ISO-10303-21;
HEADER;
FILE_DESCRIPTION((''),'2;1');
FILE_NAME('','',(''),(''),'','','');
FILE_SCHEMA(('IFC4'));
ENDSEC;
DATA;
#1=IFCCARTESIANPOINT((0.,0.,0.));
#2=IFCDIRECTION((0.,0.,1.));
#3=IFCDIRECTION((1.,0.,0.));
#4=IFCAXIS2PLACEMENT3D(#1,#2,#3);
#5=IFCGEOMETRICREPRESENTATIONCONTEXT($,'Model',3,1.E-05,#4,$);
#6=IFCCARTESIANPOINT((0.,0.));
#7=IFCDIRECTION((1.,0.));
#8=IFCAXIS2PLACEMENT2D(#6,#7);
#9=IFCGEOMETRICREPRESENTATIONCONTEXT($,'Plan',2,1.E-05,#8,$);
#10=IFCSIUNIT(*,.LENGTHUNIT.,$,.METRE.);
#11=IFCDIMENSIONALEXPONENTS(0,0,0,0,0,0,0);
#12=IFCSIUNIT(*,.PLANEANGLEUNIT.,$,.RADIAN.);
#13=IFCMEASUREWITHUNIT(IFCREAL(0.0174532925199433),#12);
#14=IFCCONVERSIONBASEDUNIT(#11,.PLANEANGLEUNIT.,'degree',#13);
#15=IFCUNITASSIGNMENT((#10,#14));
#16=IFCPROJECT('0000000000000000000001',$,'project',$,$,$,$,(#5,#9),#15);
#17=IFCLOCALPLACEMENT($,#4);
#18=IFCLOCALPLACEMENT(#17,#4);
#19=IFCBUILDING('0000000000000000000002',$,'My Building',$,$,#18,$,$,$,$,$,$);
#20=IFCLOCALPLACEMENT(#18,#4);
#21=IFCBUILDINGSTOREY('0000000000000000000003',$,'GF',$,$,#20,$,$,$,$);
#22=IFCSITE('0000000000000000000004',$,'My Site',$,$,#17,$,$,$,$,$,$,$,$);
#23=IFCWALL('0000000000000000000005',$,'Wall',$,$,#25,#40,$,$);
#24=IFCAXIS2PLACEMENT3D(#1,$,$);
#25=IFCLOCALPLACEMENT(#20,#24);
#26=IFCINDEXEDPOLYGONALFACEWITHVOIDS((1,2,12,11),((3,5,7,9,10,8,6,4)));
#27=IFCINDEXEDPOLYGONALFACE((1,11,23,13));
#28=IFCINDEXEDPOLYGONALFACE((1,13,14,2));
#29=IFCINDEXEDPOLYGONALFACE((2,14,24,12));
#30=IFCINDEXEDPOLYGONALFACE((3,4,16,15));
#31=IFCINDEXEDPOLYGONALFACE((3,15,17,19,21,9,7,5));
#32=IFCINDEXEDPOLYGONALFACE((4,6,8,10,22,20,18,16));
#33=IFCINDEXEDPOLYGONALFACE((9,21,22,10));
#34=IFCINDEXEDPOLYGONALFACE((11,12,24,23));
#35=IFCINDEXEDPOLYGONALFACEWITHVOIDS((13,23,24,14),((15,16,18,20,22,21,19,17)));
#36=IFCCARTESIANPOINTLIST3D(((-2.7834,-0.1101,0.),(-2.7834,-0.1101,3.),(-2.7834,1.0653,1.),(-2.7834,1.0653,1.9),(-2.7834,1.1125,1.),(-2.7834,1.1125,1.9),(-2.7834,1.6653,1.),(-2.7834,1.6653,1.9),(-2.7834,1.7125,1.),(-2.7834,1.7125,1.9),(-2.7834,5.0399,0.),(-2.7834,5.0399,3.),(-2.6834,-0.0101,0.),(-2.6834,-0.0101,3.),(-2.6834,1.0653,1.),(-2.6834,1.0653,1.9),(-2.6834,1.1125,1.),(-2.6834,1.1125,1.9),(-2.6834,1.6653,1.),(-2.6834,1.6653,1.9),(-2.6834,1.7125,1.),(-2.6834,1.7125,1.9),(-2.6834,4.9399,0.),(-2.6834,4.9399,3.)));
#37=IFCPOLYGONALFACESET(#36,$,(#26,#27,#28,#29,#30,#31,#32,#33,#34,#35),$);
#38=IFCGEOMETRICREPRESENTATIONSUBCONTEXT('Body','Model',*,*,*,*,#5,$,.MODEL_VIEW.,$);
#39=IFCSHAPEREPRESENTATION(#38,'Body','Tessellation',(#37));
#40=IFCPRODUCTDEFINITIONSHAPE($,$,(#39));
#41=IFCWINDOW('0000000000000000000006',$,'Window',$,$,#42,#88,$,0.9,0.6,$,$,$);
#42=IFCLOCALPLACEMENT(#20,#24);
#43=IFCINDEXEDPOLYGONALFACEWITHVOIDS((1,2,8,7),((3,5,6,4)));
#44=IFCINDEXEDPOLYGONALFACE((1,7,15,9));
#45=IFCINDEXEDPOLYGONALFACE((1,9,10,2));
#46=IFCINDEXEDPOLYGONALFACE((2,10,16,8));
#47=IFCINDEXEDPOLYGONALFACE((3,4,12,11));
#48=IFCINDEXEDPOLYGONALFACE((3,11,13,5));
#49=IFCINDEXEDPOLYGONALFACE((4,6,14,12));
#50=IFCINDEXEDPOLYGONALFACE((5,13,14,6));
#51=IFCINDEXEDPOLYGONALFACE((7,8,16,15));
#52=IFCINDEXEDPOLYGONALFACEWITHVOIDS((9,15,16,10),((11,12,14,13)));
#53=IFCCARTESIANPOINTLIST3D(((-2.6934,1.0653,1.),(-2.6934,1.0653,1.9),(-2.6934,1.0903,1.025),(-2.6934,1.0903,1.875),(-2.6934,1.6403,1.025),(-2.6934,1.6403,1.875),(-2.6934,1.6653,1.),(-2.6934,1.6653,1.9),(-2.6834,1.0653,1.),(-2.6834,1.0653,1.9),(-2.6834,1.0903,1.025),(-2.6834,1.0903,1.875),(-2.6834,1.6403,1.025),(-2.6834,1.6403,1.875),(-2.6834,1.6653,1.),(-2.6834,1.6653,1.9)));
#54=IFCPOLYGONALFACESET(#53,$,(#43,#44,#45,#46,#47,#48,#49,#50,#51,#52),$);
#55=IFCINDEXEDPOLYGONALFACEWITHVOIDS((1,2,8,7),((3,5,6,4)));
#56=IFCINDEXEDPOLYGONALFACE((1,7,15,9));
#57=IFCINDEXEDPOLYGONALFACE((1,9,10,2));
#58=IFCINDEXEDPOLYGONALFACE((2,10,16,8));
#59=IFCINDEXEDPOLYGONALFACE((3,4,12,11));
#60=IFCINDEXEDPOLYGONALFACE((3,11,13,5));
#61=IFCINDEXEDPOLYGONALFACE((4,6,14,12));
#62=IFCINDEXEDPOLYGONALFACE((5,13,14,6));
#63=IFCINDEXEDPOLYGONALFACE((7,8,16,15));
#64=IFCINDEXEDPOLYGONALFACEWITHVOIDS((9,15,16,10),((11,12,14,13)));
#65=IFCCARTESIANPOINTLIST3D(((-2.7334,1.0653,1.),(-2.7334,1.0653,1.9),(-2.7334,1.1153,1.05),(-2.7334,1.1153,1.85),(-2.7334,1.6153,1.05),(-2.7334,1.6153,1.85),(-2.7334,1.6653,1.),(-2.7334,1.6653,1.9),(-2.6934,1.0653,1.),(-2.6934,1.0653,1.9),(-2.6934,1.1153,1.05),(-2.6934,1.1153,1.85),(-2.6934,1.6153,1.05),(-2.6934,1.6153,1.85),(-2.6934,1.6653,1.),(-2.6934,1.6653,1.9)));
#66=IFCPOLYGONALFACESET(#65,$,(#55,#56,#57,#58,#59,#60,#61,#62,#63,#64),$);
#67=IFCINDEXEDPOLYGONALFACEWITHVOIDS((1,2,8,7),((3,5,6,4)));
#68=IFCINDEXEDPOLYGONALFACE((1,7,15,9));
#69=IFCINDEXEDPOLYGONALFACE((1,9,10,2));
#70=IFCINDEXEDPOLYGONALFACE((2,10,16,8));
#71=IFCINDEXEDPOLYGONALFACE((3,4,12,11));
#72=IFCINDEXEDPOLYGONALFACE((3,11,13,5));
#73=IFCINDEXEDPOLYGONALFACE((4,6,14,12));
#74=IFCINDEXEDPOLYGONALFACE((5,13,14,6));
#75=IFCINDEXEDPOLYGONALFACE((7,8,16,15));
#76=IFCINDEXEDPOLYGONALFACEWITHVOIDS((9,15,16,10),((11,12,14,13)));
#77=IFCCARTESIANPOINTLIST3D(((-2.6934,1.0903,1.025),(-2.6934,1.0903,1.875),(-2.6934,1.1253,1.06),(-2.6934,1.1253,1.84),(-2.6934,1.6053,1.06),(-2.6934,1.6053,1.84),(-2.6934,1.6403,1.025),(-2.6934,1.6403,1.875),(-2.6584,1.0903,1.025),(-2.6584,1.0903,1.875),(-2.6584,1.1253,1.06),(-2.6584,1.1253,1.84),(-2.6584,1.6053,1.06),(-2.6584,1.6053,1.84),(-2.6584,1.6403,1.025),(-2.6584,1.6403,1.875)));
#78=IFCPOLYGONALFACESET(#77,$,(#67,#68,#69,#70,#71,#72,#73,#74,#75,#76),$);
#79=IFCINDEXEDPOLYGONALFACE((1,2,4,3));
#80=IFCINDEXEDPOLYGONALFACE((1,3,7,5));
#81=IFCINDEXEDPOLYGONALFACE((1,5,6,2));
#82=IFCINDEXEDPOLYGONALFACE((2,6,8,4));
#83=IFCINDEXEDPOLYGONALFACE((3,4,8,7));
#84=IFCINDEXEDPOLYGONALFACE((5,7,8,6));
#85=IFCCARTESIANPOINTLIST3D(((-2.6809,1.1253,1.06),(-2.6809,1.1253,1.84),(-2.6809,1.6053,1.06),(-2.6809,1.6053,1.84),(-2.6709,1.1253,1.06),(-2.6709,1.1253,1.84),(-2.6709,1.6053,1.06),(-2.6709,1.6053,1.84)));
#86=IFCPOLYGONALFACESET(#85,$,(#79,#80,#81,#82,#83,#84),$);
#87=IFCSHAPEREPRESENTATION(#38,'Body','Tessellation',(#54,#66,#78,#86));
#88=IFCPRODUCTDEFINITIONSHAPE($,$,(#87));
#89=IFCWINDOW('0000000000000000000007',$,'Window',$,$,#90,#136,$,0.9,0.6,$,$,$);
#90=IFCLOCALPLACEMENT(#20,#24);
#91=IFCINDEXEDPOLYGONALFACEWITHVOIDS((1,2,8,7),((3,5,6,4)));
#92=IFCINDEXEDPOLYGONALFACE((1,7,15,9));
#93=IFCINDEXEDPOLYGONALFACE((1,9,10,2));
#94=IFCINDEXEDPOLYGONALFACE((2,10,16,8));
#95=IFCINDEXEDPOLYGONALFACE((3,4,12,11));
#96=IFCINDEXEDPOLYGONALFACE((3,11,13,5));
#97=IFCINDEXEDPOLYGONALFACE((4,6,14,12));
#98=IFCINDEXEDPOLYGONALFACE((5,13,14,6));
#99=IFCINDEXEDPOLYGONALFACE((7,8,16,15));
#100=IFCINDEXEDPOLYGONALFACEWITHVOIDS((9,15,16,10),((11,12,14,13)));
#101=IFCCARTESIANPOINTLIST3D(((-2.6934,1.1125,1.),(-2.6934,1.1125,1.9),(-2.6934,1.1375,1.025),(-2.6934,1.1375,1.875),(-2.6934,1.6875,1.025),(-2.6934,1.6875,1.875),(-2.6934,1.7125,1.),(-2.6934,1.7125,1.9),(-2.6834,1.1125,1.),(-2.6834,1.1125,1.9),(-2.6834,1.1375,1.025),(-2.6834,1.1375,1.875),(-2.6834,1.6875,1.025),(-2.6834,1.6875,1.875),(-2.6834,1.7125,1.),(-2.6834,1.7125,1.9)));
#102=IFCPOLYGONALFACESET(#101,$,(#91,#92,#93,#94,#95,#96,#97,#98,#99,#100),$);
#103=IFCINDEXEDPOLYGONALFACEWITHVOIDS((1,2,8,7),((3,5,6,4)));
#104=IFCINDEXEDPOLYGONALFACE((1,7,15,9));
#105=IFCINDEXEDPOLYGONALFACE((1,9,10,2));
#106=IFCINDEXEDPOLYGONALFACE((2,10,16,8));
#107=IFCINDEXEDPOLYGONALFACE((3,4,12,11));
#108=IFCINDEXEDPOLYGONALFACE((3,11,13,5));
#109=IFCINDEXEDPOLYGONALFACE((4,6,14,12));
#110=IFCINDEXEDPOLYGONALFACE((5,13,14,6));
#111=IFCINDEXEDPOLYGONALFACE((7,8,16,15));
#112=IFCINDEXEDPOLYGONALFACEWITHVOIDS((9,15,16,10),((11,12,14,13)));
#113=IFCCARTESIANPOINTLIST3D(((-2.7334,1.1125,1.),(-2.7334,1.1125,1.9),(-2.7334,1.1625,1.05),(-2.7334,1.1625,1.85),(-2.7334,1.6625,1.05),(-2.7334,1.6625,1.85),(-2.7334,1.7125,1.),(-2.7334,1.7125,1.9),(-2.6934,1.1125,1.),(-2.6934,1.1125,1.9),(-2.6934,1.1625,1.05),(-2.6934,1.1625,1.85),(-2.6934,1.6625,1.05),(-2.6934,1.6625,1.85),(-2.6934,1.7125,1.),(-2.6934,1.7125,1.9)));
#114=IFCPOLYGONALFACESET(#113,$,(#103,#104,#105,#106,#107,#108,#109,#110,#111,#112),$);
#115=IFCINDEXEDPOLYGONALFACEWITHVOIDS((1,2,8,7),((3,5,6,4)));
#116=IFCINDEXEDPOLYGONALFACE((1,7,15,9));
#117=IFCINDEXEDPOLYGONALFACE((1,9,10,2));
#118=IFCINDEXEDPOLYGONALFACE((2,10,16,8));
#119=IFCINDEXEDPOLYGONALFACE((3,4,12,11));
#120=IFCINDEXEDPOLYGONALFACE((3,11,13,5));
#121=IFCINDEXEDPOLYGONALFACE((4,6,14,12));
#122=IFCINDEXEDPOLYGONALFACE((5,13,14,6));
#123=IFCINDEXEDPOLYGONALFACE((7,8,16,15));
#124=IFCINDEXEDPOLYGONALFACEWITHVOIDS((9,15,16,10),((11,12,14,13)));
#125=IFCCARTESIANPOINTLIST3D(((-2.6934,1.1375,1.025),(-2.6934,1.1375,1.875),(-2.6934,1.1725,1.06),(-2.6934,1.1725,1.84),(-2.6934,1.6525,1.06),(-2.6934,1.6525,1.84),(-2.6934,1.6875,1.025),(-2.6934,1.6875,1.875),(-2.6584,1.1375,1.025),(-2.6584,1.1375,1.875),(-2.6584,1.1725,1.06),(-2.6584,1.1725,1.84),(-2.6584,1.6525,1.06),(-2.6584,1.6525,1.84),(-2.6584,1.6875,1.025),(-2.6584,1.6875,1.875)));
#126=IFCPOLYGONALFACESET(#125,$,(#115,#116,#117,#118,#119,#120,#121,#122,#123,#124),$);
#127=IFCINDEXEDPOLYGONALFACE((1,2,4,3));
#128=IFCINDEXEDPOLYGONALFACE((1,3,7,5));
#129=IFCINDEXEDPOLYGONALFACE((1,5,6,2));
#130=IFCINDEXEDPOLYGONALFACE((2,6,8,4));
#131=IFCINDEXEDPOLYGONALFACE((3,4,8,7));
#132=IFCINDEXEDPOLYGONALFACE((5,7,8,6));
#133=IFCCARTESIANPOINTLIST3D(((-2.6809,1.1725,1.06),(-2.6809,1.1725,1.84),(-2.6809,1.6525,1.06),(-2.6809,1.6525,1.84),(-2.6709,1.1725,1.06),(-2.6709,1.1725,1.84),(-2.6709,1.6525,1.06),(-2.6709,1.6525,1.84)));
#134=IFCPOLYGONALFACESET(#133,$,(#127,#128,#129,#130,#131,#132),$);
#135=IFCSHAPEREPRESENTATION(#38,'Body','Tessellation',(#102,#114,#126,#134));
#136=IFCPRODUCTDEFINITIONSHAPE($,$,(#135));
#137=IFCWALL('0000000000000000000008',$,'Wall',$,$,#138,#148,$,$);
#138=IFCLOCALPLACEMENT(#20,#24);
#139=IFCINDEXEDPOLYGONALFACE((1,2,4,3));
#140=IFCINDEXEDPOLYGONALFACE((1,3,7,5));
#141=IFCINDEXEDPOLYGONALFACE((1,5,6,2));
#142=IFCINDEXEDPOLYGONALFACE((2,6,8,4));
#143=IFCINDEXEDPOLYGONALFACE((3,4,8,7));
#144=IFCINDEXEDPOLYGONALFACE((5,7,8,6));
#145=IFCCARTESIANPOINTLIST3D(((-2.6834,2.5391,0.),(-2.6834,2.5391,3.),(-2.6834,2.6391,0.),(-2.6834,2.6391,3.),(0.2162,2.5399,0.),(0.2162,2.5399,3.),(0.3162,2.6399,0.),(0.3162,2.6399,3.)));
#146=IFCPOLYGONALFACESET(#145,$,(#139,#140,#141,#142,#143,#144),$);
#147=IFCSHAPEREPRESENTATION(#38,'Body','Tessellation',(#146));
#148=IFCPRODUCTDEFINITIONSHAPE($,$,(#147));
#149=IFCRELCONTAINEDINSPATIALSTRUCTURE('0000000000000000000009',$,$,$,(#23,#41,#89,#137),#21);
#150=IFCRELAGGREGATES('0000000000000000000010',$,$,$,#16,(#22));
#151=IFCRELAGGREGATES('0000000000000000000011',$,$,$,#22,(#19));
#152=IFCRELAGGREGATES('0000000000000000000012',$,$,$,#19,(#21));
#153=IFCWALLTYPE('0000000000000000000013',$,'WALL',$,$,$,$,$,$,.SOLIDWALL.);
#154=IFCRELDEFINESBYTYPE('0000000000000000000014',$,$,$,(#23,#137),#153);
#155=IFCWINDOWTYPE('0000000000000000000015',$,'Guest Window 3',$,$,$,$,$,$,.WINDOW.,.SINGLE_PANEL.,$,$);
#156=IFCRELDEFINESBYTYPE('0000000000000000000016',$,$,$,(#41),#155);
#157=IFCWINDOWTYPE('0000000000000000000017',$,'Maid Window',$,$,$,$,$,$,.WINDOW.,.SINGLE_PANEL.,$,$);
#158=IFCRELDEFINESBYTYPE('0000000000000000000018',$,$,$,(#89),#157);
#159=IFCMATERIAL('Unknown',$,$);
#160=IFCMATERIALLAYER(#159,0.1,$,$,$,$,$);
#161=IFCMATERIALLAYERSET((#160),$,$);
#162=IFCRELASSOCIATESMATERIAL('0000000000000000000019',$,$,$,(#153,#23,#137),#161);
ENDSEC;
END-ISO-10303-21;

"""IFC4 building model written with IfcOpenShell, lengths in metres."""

from ifc_helpers import new_model, entity, si_unit, converted_unit, frame, origin_with_axes, origin_2d_with_axis, place, context, subcontext, project, spatial, line, indexed_curve, outline, extrude, shape, source, transform, mapped, material, layer, layer_set, layer_usage, type_object, type_shapes, element, fill, save


model = new_model("IFC4")

# Units and contexts
model_context = context("Model", 3, precision=1e-05, world=origin_with_axes())
plan_context = context("Plan", 2, precision=1e-05, world=origin_2d_with_axis())
body_context_1 = subcontext(model_context, "Body", "Model", "MODEL_VIEW")
body_context_2 = subcontext(plan_context, "Body", "Plan", "PLAN_VIEW")
ifc_project = project(units=[si_unit("LENGTHUNIT", "METRE"), converted_unit("PLANEANGLEUNIT", "degree", entity("IfcReal", 0.0174532925199433), si_unit("PLANEANGLEUNIT", "RADIAN"), dimensions=[0, 0, 0, 0, 0, 0, 0])], contexts=[model_context, plan_context])

# Site, building, storey
site_placement = place(None, origin_with_axes())
site = spatial("IfcSite", under=ifc_project, at=site_placement, Name="My Site")
building_placement = place(site_placement, origin_with_axes())
building = spatial("IfcBuilding", under=site, at=building_placement, Name="My Building")
storey_placement = place(building_placement, origin_with_axes())
storey = spatial("IfcBuildingStorey", under=building, at=storey_placement, Name="GF")

# Shared definitions
ifc_material_1 = material(Name="Unknown")
ifc_layer_1 = layer(ifc_material_1, 0.1)
ifc_layer_set_1 = layer_set([ifc_layer_1])
wall_type = type_object("IfcWallType", Name="WALL", PredefinedType="SOLIDWALL", material=ifc_layer_set_1)

# Wall, openings, windows
shared_shape_1 = source(origin_with_axes(), body_context_1, "Body", "SweptSolid", [
    extrude(outline(indexed_curve([(0.0, 0.0), (0.6, 0.0), (0.6, 0.9), (0.0, 0.9)], segments=[line(1, 2, 3, 4, 1)])), frame((0.0, -0.6, 0.0), z_axis=(0.0, -1.0, 0.0), x_axis=(1.0, 0.0, 0.0)), (0.0, 0.0, -1.0), 1.2),
])
window_type_1 = type_object("IfcWindowType", Name="Maid Window", PartitioningType="SINGLE_PANEL", PredefinedType="WINDOW")
shared_shape_2 = source(origin_with_axes(), body_context_1, "Body", "SweptSolid", [
    extrude(outline(indexed_curve([(0.0, 0.0), (0.6, 0.0), (0.6, 0.9), (0.0, 0.9)], segments=[line(1, 2, 3, 4, 1)]), holes=[indexed_curve([(0.025, 0.025), (0.575, 0.025), (0.575, 0.875), (0.025, 0.875)], segments=[line(1, 2, 3, 4, 1)])]), frame((0.0, 0.09, 0.0), z_axis=(0.0, -1.0, 0.0), x_axis=(1.0, 0.0, 0.0)), (0.0, 0.0, -1.0), 0.01),
    extrude(outline(indexed_curve([(0.0, 0.0), (0.6, 0.0), (0.6, 0.9), (0.0, 0.9)], segments=[line(1, 2, 3, 4, 1)]), holes=[indexed_curve([(0.05, 0.05), (0.55, 0.05), (0.55, 0.85), (0.05, 0.85)], segments=[line(1, 2, 3, 4, 1)])]), frame((0.0, 0.05, 0.0), z_axis=(0.0, -1.0, 0.0), x_axis=(1.0, 0.0, 0.0)), (0.0, 0.0, -1.0), 0.04),
    extrude(outline(indexed_curve([(0.0, 0.0), (0.55, 0.0), (0.55, 0.85), (0.0, 0.85)], segments=[line(1, 2, 3, 4, 1)]), holes=[indexed_curve([(0.035, 0.035), (0.515, 0.035), (0.515, 0.815), (0.035, 0.815)], segments=[line(1, 2, 3, 4, 1)])]), frame((0.025, 0.09, 0.025), z_axis=(0.0, -1.0, 0.0), x_axis=(1.0, 0.0, 0.0)), (0.0, 0.0, -1.0), 0.035),
    extrude(outline(indexed_curve([(0.035, 0.035), (0.515, 0.035), (0.515, 0.815), (0.035, 0.815)], segments=[line(1, 2, 3, 4, 1)])), frame((0.025, 0.1025, 0.025), z_axis=(0.0, -1.0, 0.0), x_axis=(1.0, 0.0, 0.0)), (0.0, 0.0, -1.0), 0.01),
])
shared_shape_3 = source(origin_with_axes(), body_context_2, "Body", "Curve2D", [
    entity("IfcIndexedPolyCurve", entity("IfcCartesianPointList2D", [[0.05, 0.05], [0.55, 0.05]])),
    entity("IfcIndexedPolyCurve", entity("IfcCartesianPointList2D", [[0.0, 0.1], [0.025, 0.1], [0.025, 0.09], [0.05, 0.09], [0.05, 0.05], [0.0, 0.05]]), [entity("IfcLineIndex", [1, 2, 3, 4, 5, 6, 1])]),
    entity("IfcIndexedPolyCurve", entity("IfcCartesianPointList2D", [[0.6, 0.1], [0.575, 0.1], [0.575, 0.09], [0.55, 0.09], [0.55, 0.05], [0.6, 0.05]]), [entity("IfcLineIndex", [1, 2, 3, 4, 5, 6, 1])]),
    entity("IfcIndexedPolyCurve", entity("IfcCartesianPointList2D", [[0.025, 0.09], [0.06, 0.09], [0.06, 0.125], [0.025, 0.125]]), [entity("IfcLineIndex", [1, 2, 3, 4, 1])]),
    entity("IfcIndexedPolyCurve", entity("IfcCartesianPointList2D", [[0.575, 0.09], [0.54, 0.09], [0.54, 0.125], [0.575, 0.125]]), [entity("IfcLineIndex", [1, 2, 3, 4, 1])]),
    entity("IfcIndexedPolyCurve", entity("IfcCartesianPointList2D", [[0.06, 0.09], [0.54, 0.09]])),
    entity("IfcIndexedPolyCurve", entity("IfcCartesianPointList2D", [[0.06, 0.125], [0.54, 0.125]])),
    entity("IfcIndexedPolyCurve", entity("IfcCartesianPointList2D", [[0.06, 0.1075], [0.54, 0.1075]])),
])
type_shapes(window_type_1, [shared_shape_2, shared_shape_3])
ifc_layer_usage_1 = layer_usage(ifc_layer_set_1, "AXIS2", "POSITIVE", 0.0)
wall_1_placement = place(storey_placement, frame((-2.7834, 5.0399, 0.0), z_axis=(0.0, 0.0, 1.0), x_axis=(0.0, -1.0, 0.0)))
wall_1 = element("IfcWall", 1, at=wall_1_placement, inside=storey, type_object=wall_type, material=ifc_layer_usage_1, Name="Wall", context=body_context_1, shape_type="SweptSolid", body=[
    extrude(outline(indexed_curve([(0.0, 0.0), (0.1, 0.1), (5.05, 0.1), (5.15, 0.0)], segments=[line(1, 2, 3, 4, 1)])), origin_with_axes(), (0.0, 0.0, 1.0), 3.0),
])
opening_1_placement = place(wall_1_placement, frame((3.3274, 0.0, 1.0), z_axis=(0.0, 0.0, 1.0), x_axis=(1.0, 0.0, 0.0)))
opening_1 = element("IfcOpeningElement", 2, at=opening_1_placement, cuts=wall_1, PredefinedType="OPENING", context=body_context_1, shape_type="MappedRepresentation", body=[
    mapped(shared_shape_1, transform((0.0, 0.0, 0.0), x_axis=(1.0, 0.0, 0.0), y_axis=(0.0, 1.0, 0.0), z_axis=(0.0, 0.0, 1.0), scale=1.0)),
])
shared_shape_4 = source(origin_with_axes(), body_context_1, "Body", "SweptSolid", [
    extrude(outline(indexed_curve([(0.0, 0.0), (0.6, 0.0), (0.6, 0.9), (0.0, 0.9)], segments=[line(1, 2, 3, 4, 1)])), frame((0.0, -0.6, 0.0), z_axis=(0.0, -1.0, 0.0), x_axis=(1.0, 0.0, 0.0)), (0.0, 0.0, -1.0), 1.2),
])
opening_2_placement = place(wall_1_placement, frame((3.3746, 0.0, 1.0), z_axis=(0.0, 0.0, 1.0), x_axis=(1.0, 0.0, 0.0)))
opening_2 = element("IfcOpeningElement", 3, at=opening_2_placement, cuts=wall_1, PredefinedType="OPENING", context=body_context_1, shape_type="MappedRepresentation", body=[
    mapped(shared_shape_4, transform((0.0, 0.0, 0.0), x_axis=(1.0, 0.0, 0.0), y_axis=(0.0, 1.0, 0.0), z_axis=(0.0, 0.0, 1.0), scale=1.0)),
])
window_type_2 = type_object("IfcWindowType", Name="Guest Window 3", PartitioningType="SINGLE_PANEL", PredefinedType="WINDOW")
shared_shape_5 = source(origin_with_axes(), body_context_1, "Body", "SweptSolid", [
    extrude(outline(indexed_curve([(0.0, 0.0), (0.6, 0.0), (0.6, 0.9), (0.0, 0.9)], segments=[line(1, 2, 3, 4, 1)]), holes=[indexed_curve([(0.025, 0.025), (0.575, 0.025), (0.575, 0.875), (0.025, 0.875)], segments=[line(1, 2, 3, 4, 1)])]), frame((0.0, 0.09, 0.0), z_axis=(0.0, -1.0, 0.0), x_axis=(1.0, 0.0, 0.0)), (0.0, 0.0, -1.0), 0.01),
    extrude(outline(indexed_curve([(0.0, 0.0), (0.6, 0.0), (0.6, 0.9), (0.0, 0.9)], segments=[line(1, 2, 3, 4, 1)]), holes=[indexed_curve([(0.05, 0.05), (0.55, 0.05), (0.55, 0.85), (0.05, 0.85)], segments=[line(1, 2, 3, 4, 1)])]), frame((0.0, 0.05, 0.0), z_axis=(0.0, -1.0, 0.0), x_axis=(1.0, 0.0, 0.0)), (0.0, 0.0, -1.0), 0.04),
    extrude(outline(indexed_curve([(0.0, 0.0), (0.55, 0.0), (0.55, 0.85), (0.0, 0.85)], segments=[line(1, 2, 3, 4, 1)]), holes=[indexed_curve([(0.035, 0.035), (0.515, 0.035), (0.515, 0.815), (0.035, 0.815)], segments=[line(1, 2, 3, 4, 1)])]), frame((0.025, 0.09, 0.025), z_axis=(0.0, -1.0, 0.0), x_axis=(1.0, 0.0, 0.0)), (0.0, 0.0, -1.0), 0.035),
    extrude(outline(indexed_curve([(0.035, 0.035), (0.515, 0.035), (0.515, 0.815), (0.035, 0.815)], segments=[line(1, 2, 3, 4, 1)])), frame((0.025, 0.1025, 0.025), z_axis=(0.0, -1.0, 0.0), x_axis=(1.0, 0.0, 0.0)), (0.0, 0.0, -1.0), 0.01),
])
shared_shape_6 = source(origin_with_axes(), body_context_2, "Body", "Curve2D", [
    entity("IfcIndexedPolyCurve", entity("IfcCartesianPointList2D", [[0.05, 0.05], [0.55, 0.05]])),
    entity("IfcIndexedPolyCurve", entity("IfcCartesianPointList2D", [[0.0, 0.1], [0.025, 0.1], [0.025, 0.09], [0.05, 0.09], [0.05, 0.05], [0.0, 0.05]]), [entity("IfcLineIndex", [1, 2, 3, 4, 5, 6, 1])]),
    entity("IfcIndexedPolyCurve", entity("IfcCartesianPointList2D", [[0.6, 0.1], [0.575, 0.1], [0.575, 0.09], [0.55, 0.09], [0.55, 0.05], [0.6, 0.05]]), [entity("IfcLineIndex", [1, 2, 3, 4, 5, 6, 1])]),
    entity("IfcIndexedPolyCurve", entity("IfcCartesianPointList2D", [[0.025, 0.09], [0.06, 0.09], [0.06, 0.125], [0.025, 0.125]]), [entity("IfcLineIndex", [1, 2, 3, 4, 1])]),
    entity("IfcIndexedPolyCurve", entity("IfcCartesianPointList2D", [[0.575, 0.09], [0.54, 0.09], [0.54, 0.125], [0.575, 0.125]]), [entity("IfcLineIndex", [1, 2, 3, 4, 1])]),
    entity("IfcIndexedPolyCurve", entity("IfcCartesianPointList2D", [[0.06, 0.09], [0.54, 0.09]])),
    entity("IfcIndexedPolyCurve", entity("IfcCartesianPointList2D", [[0.06, 0.125], [0.54, 0.125]])),
    entity("IfcIndexedPolyCurve", entity("IfcCartesianPointList2D", [[0.06, 0.1075], [0.54, 0.1075]])),
])
type_shapes(window_type_2, [shared_shape_5, shared_shape_6])
window_1_placement = place(opening_2_placement, frame((0.0, 0.0, 0.0), z_axis=(0.0, 0.0, 1.0), x_axis=(1.0, 0.0, 0.0)))
window_1 = element("IfcWindow", 4, at=window_1_placement, inside=storey, type_object=window_type_2, Name="Window", OverallHeight=0.9, OverallWidth=0.6, shapes=[
    shape(body_context_1, "Body", "MappedRepresentation", [mapped(shared_shape_5, transform((0.0, 0.0, 0.0), x_axis=(1.0, 0.0, 0.0), y_axis=(0.0, 1.0, 0.0), z_axis=(0.0, 0.0, 1.0), scale=1.0))]),
    shape(body_context_2, "Body", "MappedRepresentation", [mapped(shared_shape_6, transform((0.0, 0.0, 0.0), x_axis=(1.0, 0.0, 0.0), y_axis=(0.0, 1.0, 0.0), z_axis=(0.0, 0.0, 1.0), scale=1.0))]),
])
fill(opening_2, window_1)
window_2_placement = place(opening_1_placement, frame((0.0, 0.0, 0.0), z_axis=(0.0, 0.0, 1.0), x_axis=(1.0, 0.0, 0.0)))
window_2 = element("IfcWindow", 5, at=window_2_placement, inside=storey, type_object=window_type_1, Name="Window", OverallHeight=0.9, OverallWidth=0.6, shapes=[
    shape(body_context_1, "Body", "MappedRepresentation", [mapped(shared_shape_2, transform((0.0, 0.0, 0.0), x_axis=(1.0, 0.0, 0.0), y_axis=(0.0, 1.0, 0.0), z_axis=(0.0, 0.0, 1.0), scale=1.0))]),
    shape(body_context_2, "Body", "MappedRepresentation", [mapped(shared_shape_3, transform((0.0, 0.0, 0.0), x_axis=(1.0, 0.0, 0.0), y_axis=(0.0, 1.0, 0.0), z_axis=(0.0, 0.0, 1.0), scale=1.0))]),
])
fill(opening_1, window_2)

# Wall
ifc_layer_usage_2 = layer_usage(ifc_layer_set_1, "AXIS2", "POSITIVE", 0.0)
wall_2_placement = place(storey_placement, frame((0.3162, 2.6399, 0.0), z_axis=(0.0, 0.0, 1.0), x_axis=(-1.0, -0.00025, 0.0)))
element("IfcWall", 6, at=wall_2_placement, inside=storey, type_object=wall_type, material=ifc_layer_usage_2, Name="Wall", context=body_context_1, shape_type="SweptSolid", body=[
    extrude(outline(indexed_curve([(0.0, 0.0), (0.1, 0.1), (2.9996, 0.1), (2.9996, 0.0)], segments=[line(1, 2, 3, 4, 1)])), origin_with_axes(), (0.0, 0.0, 1.0), 3.0),
])

save(model, "model.ifc")
